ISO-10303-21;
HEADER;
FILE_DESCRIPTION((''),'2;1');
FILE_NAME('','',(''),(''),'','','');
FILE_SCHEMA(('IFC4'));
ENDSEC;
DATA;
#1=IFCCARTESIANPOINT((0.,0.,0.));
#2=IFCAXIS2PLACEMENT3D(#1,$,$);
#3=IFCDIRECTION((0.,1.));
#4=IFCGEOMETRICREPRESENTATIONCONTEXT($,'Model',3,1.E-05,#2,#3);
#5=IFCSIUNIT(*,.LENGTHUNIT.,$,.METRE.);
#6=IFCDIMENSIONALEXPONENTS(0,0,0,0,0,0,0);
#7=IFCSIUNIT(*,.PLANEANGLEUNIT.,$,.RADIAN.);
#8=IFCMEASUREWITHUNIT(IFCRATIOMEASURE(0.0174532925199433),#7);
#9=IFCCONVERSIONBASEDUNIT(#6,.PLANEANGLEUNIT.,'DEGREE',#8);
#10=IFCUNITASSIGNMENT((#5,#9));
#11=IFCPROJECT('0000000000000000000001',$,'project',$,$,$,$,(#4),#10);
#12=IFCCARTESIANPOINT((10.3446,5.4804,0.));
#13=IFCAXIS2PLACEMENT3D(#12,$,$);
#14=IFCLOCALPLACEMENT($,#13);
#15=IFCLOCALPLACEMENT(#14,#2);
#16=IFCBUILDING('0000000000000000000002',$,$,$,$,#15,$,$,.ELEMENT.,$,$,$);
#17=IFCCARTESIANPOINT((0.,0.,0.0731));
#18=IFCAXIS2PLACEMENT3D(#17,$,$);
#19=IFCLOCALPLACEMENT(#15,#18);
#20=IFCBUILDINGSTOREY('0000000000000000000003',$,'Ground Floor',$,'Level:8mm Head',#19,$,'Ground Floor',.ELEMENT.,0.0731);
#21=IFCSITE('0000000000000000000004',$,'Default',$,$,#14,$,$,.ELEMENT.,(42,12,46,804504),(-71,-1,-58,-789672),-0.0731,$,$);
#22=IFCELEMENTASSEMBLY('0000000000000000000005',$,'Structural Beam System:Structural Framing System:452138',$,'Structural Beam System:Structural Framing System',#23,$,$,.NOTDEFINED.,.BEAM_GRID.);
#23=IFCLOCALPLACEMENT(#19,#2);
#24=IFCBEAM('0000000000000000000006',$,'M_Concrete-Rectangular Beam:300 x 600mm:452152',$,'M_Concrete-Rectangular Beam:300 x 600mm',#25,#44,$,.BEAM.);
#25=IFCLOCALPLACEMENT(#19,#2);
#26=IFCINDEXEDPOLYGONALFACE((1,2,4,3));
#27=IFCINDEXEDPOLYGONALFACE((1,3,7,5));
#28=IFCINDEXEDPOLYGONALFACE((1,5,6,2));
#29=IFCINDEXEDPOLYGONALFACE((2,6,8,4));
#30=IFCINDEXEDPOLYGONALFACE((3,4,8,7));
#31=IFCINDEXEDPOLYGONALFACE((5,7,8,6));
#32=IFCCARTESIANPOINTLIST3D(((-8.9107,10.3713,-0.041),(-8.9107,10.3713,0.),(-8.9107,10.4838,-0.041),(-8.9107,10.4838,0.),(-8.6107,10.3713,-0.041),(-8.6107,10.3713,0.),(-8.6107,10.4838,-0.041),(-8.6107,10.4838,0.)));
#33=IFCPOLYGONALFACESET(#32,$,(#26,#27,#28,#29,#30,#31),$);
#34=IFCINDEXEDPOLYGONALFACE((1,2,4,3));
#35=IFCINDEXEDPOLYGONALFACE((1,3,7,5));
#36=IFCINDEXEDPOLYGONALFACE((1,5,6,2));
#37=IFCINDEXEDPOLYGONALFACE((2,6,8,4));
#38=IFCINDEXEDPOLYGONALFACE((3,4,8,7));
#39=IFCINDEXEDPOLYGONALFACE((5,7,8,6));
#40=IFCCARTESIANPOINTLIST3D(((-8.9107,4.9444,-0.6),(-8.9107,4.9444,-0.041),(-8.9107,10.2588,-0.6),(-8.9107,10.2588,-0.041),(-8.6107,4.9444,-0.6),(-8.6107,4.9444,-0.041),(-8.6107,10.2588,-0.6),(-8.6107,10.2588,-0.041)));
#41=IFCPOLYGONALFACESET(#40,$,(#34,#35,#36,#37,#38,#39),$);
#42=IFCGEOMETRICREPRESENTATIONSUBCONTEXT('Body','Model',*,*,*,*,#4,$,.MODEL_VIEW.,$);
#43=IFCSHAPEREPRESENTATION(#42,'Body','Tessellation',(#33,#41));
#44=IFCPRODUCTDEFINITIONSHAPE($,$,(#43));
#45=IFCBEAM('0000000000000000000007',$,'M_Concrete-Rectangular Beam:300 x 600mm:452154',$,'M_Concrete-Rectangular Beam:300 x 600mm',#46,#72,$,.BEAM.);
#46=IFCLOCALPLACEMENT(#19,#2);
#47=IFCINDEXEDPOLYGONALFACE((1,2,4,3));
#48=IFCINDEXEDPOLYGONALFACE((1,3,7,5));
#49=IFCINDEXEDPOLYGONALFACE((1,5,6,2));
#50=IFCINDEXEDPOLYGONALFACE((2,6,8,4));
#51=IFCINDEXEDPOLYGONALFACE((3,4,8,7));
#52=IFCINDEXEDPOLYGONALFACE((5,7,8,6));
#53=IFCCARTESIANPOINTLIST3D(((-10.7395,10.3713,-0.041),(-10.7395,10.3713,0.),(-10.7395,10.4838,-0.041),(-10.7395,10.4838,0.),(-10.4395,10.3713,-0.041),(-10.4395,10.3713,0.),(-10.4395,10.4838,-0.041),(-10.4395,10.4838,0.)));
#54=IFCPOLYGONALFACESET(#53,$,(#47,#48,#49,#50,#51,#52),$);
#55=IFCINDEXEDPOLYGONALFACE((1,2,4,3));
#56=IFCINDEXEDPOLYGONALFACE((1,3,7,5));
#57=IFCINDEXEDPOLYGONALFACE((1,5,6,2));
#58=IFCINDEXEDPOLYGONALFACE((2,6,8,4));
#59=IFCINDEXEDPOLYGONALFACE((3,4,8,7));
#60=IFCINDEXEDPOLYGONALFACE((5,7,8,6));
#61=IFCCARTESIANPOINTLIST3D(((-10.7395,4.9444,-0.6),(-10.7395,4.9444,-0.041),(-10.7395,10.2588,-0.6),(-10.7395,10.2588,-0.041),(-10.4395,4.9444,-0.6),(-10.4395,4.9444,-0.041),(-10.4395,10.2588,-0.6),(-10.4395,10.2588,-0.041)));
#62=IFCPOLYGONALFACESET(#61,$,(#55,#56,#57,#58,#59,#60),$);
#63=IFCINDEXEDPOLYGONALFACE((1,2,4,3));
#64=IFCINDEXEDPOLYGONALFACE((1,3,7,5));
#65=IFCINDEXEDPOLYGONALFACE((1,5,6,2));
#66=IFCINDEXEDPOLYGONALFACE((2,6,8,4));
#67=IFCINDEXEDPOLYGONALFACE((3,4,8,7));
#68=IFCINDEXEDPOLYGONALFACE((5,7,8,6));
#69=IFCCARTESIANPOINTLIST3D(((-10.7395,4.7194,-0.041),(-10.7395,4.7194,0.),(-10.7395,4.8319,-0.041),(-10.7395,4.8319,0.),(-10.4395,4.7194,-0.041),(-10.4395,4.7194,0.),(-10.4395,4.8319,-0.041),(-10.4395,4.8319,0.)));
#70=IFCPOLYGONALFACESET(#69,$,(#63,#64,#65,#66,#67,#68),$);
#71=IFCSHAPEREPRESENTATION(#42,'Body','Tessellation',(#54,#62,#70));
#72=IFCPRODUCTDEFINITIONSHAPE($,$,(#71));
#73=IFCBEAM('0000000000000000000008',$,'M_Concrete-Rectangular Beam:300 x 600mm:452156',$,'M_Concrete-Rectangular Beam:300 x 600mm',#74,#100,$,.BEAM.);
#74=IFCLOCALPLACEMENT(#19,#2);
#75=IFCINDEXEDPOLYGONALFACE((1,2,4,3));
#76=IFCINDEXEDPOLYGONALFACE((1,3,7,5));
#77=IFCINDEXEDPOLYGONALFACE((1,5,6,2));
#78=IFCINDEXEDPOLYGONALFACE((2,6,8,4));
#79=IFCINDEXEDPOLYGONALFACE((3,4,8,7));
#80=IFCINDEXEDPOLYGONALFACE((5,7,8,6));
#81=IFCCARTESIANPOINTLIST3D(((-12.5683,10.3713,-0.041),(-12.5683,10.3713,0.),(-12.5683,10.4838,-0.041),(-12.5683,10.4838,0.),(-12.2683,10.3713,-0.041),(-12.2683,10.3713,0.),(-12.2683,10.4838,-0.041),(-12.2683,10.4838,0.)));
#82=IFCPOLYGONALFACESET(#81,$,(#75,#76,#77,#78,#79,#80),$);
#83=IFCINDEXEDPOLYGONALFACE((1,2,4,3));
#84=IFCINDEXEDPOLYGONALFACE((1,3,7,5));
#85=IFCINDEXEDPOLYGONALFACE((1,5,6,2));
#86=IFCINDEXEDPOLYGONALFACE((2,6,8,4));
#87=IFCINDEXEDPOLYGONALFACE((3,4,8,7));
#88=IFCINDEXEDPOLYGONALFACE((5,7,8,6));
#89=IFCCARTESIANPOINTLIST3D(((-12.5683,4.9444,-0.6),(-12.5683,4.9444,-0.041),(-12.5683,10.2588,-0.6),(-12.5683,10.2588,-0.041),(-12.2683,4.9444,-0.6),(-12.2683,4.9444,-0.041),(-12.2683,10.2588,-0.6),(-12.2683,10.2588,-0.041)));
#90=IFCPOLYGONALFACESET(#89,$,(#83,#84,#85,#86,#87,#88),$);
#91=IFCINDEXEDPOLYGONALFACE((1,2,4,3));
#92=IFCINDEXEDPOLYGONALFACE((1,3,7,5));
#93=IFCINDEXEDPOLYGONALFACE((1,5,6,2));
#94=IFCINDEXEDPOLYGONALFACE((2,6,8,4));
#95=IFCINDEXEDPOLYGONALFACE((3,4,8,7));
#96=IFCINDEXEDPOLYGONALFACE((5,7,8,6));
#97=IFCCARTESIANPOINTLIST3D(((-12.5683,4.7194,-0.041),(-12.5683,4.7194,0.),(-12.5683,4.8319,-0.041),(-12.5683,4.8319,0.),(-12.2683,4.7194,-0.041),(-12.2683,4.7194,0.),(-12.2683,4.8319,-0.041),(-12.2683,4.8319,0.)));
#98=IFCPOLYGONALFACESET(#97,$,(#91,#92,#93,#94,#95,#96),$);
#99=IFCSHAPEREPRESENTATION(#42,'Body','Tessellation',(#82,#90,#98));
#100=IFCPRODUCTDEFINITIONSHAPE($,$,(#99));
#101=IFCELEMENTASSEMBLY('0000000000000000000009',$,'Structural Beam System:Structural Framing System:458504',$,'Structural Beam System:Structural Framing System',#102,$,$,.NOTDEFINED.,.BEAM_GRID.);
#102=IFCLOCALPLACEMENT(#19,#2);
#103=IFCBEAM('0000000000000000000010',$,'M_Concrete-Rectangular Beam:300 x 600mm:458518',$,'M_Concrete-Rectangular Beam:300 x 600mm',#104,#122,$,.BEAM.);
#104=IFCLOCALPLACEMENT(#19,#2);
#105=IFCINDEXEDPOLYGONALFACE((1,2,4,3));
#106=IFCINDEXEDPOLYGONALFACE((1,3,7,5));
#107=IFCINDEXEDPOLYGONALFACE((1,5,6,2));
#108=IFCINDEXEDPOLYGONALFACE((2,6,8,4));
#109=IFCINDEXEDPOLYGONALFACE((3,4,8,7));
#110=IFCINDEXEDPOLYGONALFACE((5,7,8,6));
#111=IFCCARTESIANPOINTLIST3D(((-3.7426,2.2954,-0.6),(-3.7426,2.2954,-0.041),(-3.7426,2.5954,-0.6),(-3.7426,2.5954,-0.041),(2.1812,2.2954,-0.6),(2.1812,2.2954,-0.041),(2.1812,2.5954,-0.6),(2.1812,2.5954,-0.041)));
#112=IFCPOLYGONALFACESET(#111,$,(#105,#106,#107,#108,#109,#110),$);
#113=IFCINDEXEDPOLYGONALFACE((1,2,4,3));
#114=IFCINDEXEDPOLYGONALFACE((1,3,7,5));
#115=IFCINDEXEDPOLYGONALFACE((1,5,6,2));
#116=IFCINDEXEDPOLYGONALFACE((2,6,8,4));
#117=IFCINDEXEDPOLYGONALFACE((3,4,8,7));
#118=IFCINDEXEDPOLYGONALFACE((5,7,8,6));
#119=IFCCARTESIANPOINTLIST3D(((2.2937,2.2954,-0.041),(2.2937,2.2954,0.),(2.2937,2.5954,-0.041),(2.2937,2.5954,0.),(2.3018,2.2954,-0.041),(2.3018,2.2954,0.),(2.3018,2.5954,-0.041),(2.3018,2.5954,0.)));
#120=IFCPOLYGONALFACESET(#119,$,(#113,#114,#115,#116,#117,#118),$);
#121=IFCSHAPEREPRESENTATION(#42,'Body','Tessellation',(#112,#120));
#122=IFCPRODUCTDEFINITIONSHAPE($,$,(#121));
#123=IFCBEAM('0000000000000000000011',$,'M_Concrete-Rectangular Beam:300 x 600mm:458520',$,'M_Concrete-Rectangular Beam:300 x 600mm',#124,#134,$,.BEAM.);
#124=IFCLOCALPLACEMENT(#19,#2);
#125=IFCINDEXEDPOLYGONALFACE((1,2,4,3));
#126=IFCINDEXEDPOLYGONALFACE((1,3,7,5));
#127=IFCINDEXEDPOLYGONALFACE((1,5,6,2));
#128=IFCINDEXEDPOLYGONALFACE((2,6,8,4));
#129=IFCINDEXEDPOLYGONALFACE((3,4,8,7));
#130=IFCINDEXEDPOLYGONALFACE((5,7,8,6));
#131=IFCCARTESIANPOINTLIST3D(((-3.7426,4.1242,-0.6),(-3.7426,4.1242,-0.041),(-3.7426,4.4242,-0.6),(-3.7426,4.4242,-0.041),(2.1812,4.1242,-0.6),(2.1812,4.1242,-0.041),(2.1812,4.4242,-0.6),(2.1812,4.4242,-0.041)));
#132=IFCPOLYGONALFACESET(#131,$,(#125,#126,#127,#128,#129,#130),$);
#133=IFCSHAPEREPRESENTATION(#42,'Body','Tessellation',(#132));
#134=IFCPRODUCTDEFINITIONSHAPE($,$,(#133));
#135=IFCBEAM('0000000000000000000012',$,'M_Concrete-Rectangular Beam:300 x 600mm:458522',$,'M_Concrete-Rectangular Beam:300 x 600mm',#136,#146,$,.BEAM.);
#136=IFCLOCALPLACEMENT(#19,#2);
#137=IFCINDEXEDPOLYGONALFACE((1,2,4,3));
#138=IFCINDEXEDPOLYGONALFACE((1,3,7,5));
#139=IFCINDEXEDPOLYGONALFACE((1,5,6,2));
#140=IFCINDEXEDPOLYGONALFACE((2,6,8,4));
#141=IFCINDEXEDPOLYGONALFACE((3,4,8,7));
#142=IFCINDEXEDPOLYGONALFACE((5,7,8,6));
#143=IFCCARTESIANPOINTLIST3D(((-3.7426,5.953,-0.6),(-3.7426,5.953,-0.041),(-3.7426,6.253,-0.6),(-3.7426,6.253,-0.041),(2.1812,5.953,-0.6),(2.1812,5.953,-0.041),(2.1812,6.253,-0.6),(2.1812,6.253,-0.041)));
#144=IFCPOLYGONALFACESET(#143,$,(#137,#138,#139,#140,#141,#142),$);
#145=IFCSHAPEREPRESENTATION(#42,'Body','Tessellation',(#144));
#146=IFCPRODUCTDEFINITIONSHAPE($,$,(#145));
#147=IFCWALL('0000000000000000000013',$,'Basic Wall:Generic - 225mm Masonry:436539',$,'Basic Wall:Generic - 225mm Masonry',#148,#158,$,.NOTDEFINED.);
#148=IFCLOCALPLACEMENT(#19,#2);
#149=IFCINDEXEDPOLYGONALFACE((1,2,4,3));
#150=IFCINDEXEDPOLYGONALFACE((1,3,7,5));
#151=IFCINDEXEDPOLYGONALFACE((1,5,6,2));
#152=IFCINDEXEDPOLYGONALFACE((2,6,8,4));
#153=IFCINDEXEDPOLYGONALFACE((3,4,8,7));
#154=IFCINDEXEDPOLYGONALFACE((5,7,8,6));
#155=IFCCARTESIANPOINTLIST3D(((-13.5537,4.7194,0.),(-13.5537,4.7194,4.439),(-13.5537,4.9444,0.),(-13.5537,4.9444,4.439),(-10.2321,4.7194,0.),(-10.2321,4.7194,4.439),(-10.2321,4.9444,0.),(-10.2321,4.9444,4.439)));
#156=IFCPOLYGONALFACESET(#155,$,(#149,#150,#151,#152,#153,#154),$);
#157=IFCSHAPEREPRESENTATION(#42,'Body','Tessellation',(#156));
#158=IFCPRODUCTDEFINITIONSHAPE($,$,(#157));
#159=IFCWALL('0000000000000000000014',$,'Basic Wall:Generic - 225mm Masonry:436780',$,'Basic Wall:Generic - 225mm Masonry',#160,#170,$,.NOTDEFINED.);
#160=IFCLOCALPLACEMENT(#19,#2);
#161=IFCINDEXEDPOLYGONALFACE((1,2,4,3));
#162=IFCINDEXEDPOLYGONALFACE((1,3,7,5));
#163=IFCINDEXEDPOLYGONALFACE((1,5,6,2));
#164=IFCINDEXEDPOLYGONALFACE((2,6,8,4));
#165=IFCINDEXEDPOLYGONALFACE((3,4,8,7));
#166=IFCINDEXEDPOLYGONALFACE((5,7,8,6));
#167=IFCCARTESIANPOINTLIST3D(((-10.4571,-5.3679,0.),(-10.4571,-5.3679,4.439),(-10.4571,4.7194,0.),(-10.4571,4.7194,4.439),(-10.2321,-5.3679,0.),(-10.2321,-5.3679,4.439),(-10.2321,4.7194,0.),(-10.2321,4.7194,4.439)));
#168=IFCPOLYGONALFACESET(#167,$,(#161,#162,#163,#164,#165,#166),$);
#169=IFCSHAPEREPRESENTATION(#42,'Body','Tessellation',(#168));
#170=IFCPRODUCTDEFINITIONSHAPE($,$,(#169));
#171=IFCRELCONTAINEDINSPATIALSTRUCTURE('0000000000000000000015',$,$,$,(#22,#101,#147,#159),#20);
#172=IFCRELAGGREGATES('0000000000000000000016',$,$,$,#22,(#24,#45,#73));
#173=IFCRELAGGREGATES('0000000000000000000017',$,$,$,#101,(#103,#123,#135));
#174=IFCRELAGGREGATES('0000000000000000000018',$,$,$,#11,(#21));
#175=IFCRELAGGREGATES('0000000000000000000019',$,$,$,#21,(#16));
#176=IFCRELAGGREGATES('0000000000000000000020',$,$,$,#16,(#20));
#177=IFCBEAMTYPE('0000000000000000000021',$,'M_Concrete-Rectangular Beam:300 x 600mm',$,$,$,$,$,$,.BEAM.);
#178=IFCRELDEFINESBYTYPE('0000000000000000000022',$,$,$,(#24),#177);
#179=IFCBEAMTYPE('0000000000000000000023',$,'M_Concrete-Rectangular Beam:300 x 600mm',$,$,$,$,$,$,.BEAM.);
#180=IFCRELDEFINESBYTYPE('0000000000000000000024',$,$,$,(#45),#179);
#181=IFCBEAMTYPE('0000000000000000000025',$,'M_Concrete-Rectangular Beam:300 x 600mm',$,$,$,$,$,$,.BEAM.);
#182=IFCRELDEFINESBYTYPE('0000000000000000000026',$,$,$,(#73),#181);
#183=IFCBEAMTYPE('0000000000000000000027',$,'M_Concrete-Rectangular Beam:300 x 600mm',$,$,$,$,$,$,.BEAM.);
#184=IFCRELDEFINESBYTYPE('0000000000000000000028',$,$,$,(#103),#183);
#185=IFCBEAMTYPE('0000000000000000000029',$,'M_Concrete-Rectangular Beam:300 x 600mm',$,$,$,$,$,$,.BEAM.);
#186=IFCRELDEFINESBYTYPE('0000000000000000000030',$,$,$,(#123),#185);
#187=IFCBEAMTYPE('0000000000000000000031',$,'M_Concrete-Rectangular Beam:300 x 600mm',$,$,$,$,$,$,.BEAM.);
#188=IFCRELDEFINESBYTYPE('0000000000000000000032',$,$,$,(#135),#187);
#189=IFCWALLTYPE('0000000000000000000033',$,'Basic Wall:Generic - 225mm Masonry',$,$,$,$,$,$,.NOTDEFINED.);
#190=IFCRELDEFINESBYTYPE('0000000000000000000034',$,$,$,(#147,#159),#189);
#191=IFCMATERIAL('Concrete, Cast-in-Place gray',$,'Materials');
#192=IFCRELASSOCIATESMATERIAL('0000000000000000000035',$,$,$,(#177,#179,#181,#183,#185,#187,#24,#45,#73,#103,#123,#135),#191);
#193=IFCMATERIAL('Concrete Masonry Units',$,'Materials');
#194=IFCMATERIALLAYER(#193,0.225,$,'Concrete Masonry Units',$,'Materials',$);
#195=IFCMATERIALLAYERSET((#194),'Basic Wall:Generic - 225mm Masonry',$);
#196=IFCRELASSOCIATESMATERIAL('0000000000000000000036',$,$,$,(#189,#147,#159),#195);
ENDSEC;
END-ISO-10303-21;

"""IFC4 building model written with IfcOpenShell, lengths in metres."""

from ifc_helpers import new_model, entity, si_unit, converted_unit, direction, frame, frame_2d, origin, place, context, subcontext, project, spatial, polyline, rectangle, extrude, clip, bounded_halfspace, source, transform, mapped, material, layer, layer_set, layer_usage, material_profile, profile_set, profile_usage, type_object, type_shapes, element, aggregate, save


model = new_model("IFC4")

# Units and contexts
model_context = context("Model", 3, precision=1e-05, world=origin(), true_north=direction((0.0, 1.0)))
body_context = subcontext(model_context, "Body", "Model", "MODEL_VIEW")
ifc_project = project(units=[si_unit("LENGTHUNIT", "METRE"), converted_unit("PLANEANGLEUNIT", "DEGREE", entity("IfcRatioMeasure", 0.0174532925199433), si_unit("PLANEANGLEUNIT", "RADIAN"), dimensions=[0, 0, 0, 0, 0, 0, 0])], contexts=[model_context])

# Site, building, storey
site_placement = place(None, frame((10.3446, 5.4804, 0.0)))
site = spatial("IfcSite", under=ifc_project, at=site_placement, Name="Default", CompositionType="ELEMENT", RefLatitude=(42, 12, 46, 804504), RefLongitude=(-71, -1, -58, -789672), RefElevation=-0.0731)
building_placement = place(site_placement, origin())
building = spatial("IfcBuilding", under=site, at=building_placement, CompositionType="ELEMENT")
storey_placement = place(building_placement, frame((0.0, 0.0, 0.0731)))
storey = spatial("IfcBuildingStorey", under=building, at=storey_placement, Name="Ground Floor", ObjectType="Level:8mm Head", LongName="Ground Floor", CompositionType="ELEMENT", Elevation=0.0731)

# Element assemblies, beams
ifc_material_1 = material(Name="Concrete, Cast-in-Place gray", Category="Materials")
ifc_material_profile = material_profile(ifc_material_1, rectangle(XDim=0.559, YDim=0.3, at=frame_2d((0.0, 0.0), x_axis=(1.0, 0.0))), Name="300 x 600mm")
ifc_profile_set = profile_set([ifc_material_profile], Name="300 x 600mm")
assembly_1_placement = place(storey_placement, origin())
assembly_1 = element("IfcElementAssembly", 1, at=assembly_1_placement, inside=storey, Name="Structural Beam System:Structural Framing System:452138", ObjectType="Structural Beam System:Structural Framing System", AssemblyPlace="NOTDEFINED", PredefinedType="BEAM_GRID")
ifc_profile_usage_1 = profile_usage(ifc_profile_set, cardinal=8)
beam_type_1 = type_object("IfcBeamType", Name="M_Concrete-Rectangular Beam:300 x 600mm", PredefinedType="BEAM", material=ifc_profile_set)
shared_shape_1 = source(origin(), body_context, "Body", "SweptSolid", [
    extrude(rectangle(XDim=0.041, YDim=0.3, at=frame_2d((0.0, 0.0), x_axis=(0.0, 1.0))), frame((-8.7607, 10.4838, 0.0526), z_axis=(0.0, -1.0, 0.0), x_axis=(-1.0, 0.0, 0.0)), (0.0, 0.0, 1.0), 0.1125),
    extrude(rectangle(XDim=0.559, YDim=0.3, at=frame_2d((0.0, 0.0), x_axis=(0.0, 1.0))), frame((-8.7607, 10.2588, -0.2474), z_axis=(0.0, -1.0, 0.0), x_axis=(-1.0, 0.0, 0.0)), (0.0, 0.0, 1.0), 5.3144),
])
type_shapes(beam_type_1, [shared_shape_1])
beam_1_placement = place(assembly_1_placement, frame((0.0, 0.0, -0.0731)))
beam_1 = element("IfcBeam", 2, at=beam_1_placement, type_object=beam_type_1, material=ifc_profile_usage_1, Name="M_Concrete-Rectangular Beam:300 x 600mm:452152", ObjectType="M_Concrete-Rectangular Beam:300 x 600mm", PredefinedType="BEAM", context=body_context, shape_type="MappedRepresentation", body=[
    mapped(shared_shape_1, transform((0.0, 0.0, 0.0), scale=1.0)),
])
ifc_profile_usage_2 = profile_usage(ifc_profile_set, cardinal=8)
beam_type_2 = type_object("IfcBeamType", Name="M_Concrete-Rectangular Beam:300 x 600mm", PredefinedType="BEAM", material=ifc_profile_set)
shared_shape_2 = source(origin(), body_context, "Body", "SweptSolid", [
    extrude(rectangle(XDim=0.041, YDim=0.3, at=frame_2d((0.0, 0.0), x_axis=(0.0, 1.0))), frame((-10.5895, 10.4838, 0.0526), z_axis=(0.0, -1.0, 0.0), x_axis=(-1.0, 0.0, 0.0)), (0.0, 0.0, 1.0), 0.1125),
    extrude(rectangle(XDim=0.559, YDim=0.3, at=frame_2d((0.0, 0.0), x_axis=(0.0, 1.0))), frame((-10.5895, 10.2588, -0.2474), z_axis=(0.0, -1.0, 0.0), x_axis=(-1.0, 0.0, 0.0)), (0.0, 0.0, 1.0), 5.3144),
    extrude(rectangle(XDim=0.041, YDim=0.3, at=frame_2d((0.0, 0.0), x_axis=(0.0, 1.0))), frame((-10.5895, 4.8319, 0.0526), z_axis=(0.0, -1.0, 0.0), x_axis=(-1.0, 0.0, 0.0)), (0.0, 0.0, 1.0), 0.1125),
])
type_shapes(beam_type_2, [shared_shape_2])
beam_2_placement = place(assembly_1_placement, frame((0.0, 0.0, -0.0731)))
beam_2 = element("IfcBeam", 3, at=beam_2_placement, type_object=beam_type_2, material=ifc_profile_usage_2, Name="M_Concrete-Rectangular Beam:300 x 600mm:452154", ObjectType="M_Concrete-Rectangular Beam:300 x 600mm", PredefinedType="BEAM", context=body_context, shape_type="MappedRepresentation", body=[
    mapped(shared_shape_2, transform((0.0, 0.0, 0.0), scale=1.0)),
])
ifc_profile_usage_3 = profile_usage(ifc_profile_set, cardinal=8)
beam_type_3 = type_object("IfcBeamType", Name="M_Concrete-Rectangular Beam:300 x 600mm", PredefinedType="BEAM", material=ifc_profile_set)
shared_shape_3 = source(origin(), body_context, "Body", "SweptSolid", [
    extrude(rectangle(XDim=0.041, YDim=0.3, at=frame_2d((0.0, 0.0), x_axis=(0.0, 1.0))), frame((-12.4183, 10.4838, 0.0526), z_axis=(0.0, -1.0, 0.0), x_axis=(-1.0, 0.0, 0.0)), (0.0, 0.0, 1.0), 0.1125),
    extrude(rectangle(XDim=0.559, YDim=0.3, at=frame_2d((0.0, 0.0), x_axis=(0.0, 1.0))), frame((-12.4183, 10.2588, -0.2474), z_axis=(0.0, -1.0, 0.0), x_axis=(-1.0, 0.0, 0.0)), (0.0, 0.0, 1.0), 5.3144),
    extrude(rectangle(XDim=0.041, YDim=0.3, at=frame_2d((0.0, 0.0), x_axis=(0.0, 1.0))), frame((-12.4183, 4.8319, 0.0526), z_axis=(0.0, -1.0, 0.0), x_axis=(-1.0, 0.0, 0.0)), (0.0, 0.0, 1.0), 0.1125),
])
type_shapes(beam_type_3, [shared_shape_3])
beam_3_placement = place(assembly_1_placement, frame((0.0, 0.0, -0.0731)))
beam_3 = element("IfcBeam", 4, at=beam_3_placement, type_object=beam_type_3, material=ifc_profile_usage_3, Name="M_Concrete-Rectangular Beam:300 x 600mm:452156", ObjectType="M_Concrete-Rectangular Beam:300 x 600mm", PredefinedType="BEAM", context=body_context, shape_type="MappedRepresentation", body=[
    mapped(shared_shape_3, transform((0.0, 0.0, 0.0), scale=1.0)),
])
aggregate(assembly_1, [beam_1, beam_2, beam_3])
assembly_2_placement = place(storey_placement, origin())
assembly_2 = element("IfcElementAssembly", 5, at=assembly_2_placement, inside=storey, Name="Structural Beam System:Structural Framing System:458504", ObjectType="Structural Beam System:Structural Framing System", AssemblyPlace="NOTDEFINED", PredefinedType="BEAM_GRID")
ifc_profile_usage_4 = profile_usage(ifc_profile_set, cardinal=8)
beam_type_4 = type_object("IfcBeamType", Name="M_Concrete-Rectangular Beam:300 x 600mm", PredefinedType="BEAM", material=ifc_profile_set)
shared_shape_4 = source(origin(), body_context, "Body", "SweptSolid", [
    extrude(rectangle(XDim=0.559, YDim=0.3, at=frame_2d((0.0, 0.0), x_axis=(1.0, 0.0))), frame((2.1812, 2.4454, -0.2474), z_axis=(-1.0, 0.0, 0.0), x_axis=(0.0, 0.0, -1.0)), (0.0, 0.0, 1.0), 5.9238),
    extrude(rectangle(XDim=0.041, YDim=0.3, at=frame_2d((0.0, 0.0), x_axis=(1.0, 0.0))), frame((2.3018, 2.4454, 0.0526), z_axis=(-1.0, 0.0, 0.0), x_axis=(0.0, 0.0, -1.0)), (0.0, 0.0, 1.0), 0.0082),
])
type_shapes(beam_type_4, [shared_shape_4])
beam_4_placement = place(assembly_2_placement, frame((0.0, 0.0, -0.0731)))
beam_4 = element("IfcBeam", 6, at=beam_4_placement, type_object=beam_type_4, material=ifc_profile_usage_4, Name="M_Concrete-Rectangular Beam:300 x 600mm:458518", ObjectType="M_Concrete-Rectangular Beam:300 x 600mm", PredefinedType="BEAM", context=body_context, shape_type="MappedRepresentation", body=[
    mapped(shared_shape_4, transform((0.0, 0.0, 0.0), scale=1.0)),
])
ifc_profile_usage_5 = profile_usage(ifc_profile_set, cardinal=8)
beam_type_5 = type_object("IfcBeamType", Name="M_Concrete-Rectangular Beam:300 x 600mm", PredefinedType="BEAM", material=ifc_profile_set)
shared_shape_5 = source(origin(), body_context, "Body", "SweptSolid", [
    extrude(rectangle(XDim=0.559, YDim=0.3, at=frame_2d((0.0, 0.0), x_axis=(1.0, 0.0))), frame((2.1812, 4.2742, -0.2474), z_axis=(-1.0, 0.0, 0.0), x_axis=(0.0, 0.0, -1.0)), (0.0, 0.0, 1.0), 5.9238),
])
type_shapes(beam_type_5, [shared_shape_5])
beam_5_placement = place(assembly_2_placement, frame((0.0, 0.0, -0.0731)))
beam_5 = element("IfcBeam", 7, at=beam_5_placement, type_object=beam_type_5, material=ifc_profile_usage_5, Name="M_Concrete-Rectangular Beam:300 x 600mm:458520", ObjectType="M_Concrete-Rectangular Beam:300 x 600mm", PredefinedType="BEAM", context=body_context, shape_type="MappedRepresentation", body=[
    mapped(shared_shape_5, transform((0.0, 0.0, 0.0), scale=1.0)),
])
ifc_profile_usage_6 = profile_usage(ifc_profile_set, cardinal=8)
beam_type_6 = type_object("IfcBeamType", Name="M_Concrete-Rectangular Beam:300 x 600mm", PredefinedType="BEAM", material=ifc_profile_set)
shared_shape_6 = source(origin(), body_context, "Body", "SweptSolid", [
    extrude(rectangle(XDim=0.559, YDim=0.3, at=frame_2d((0.0, 0.0), x_axis=(1.0, 0.0))), frame((2.1812, 6.103, -0.2474), z_axis=(-1.0, 0.0, 0.0), x_axis=(0.0, 0.0, -1.0)), (0.0, 0.0, 1.0), 5.9238),
])
type_shapes(beam_type_6, [shared_shape_6])
beam_6_placement = place(assembly_2_placement, frame((0.0, 0.0, -0.0731)))
beam_6 = element("IfcBeam", 8, at=beam_6_placement, type_object=beam_type_6, material=ifc_profile_usage_6, Name="M_Concrete-Rectangular Beam:300 x 600mm:458522", ObjectType="M_Concrete-Rectangular Beam:300 x 600mm", PredefinedType="BEAM", context=body_context, shape_type="MappedRepresentation", body=[
    mapped(shared_shape_6, transform((0.0, 0.0, 0.0), scale=1.0)),
])
aggregate(assembly_2, [beam_4, beam_5, beam_6])

# Walls
ifc_material_2 = material(Name="Concrete Masonry Units", Category="Materials")
ifc_layer = layer(ifc_material_2, 0.225, Name="Concrete Masonry Units", Category="Materials")
ifc_layer_set = layer_set([ifc_layer], Name="Basic Wall:Generic - 225mm Masonry")
wall_type = type_object("IfcWallType", Name="Basic Wall:Generic - 225mm Masonry", PredefinedType="NOTDEFINED", material=ifc_layer_set)
ifc_layer_usage_1 = layer_usage(ifc_layer_set, "AXIS2", "NEGATIVE", 0.1125)
wall_1_placement = place(storey_placement, frame((-13.5537, 4.8319, 0.0)))
element("IfcWall", 9, at=wall_1_placement, inside=storey, type_object=wall_type, material=ifc_layer_usage_1, Name="Basic Wall:Generic - 225mm Masonry:436539", ObjectType="Basic Wall:Generic - 225mm Masonry", PredefinedType="NOTDEFINED", context=body_context, shape_type="Clipping", body=[
    clip(extrude(rectangle(XDim=3.3216, YDim=0.225, at=frame_2d((1.6608, 0.0), x_axis=(-1.0, 0.0))), origin(), (0.0, 0.0, 1.0), 4.439), bounded_halfspace(frame((3.2091, -0.1125, 4.439), z_axis=(0.0, 0.0, -1.0), x_axis=(0.0, -1.0, 0.0)), True, frame((3.2091, -0.1125, 4.439)), polyline([(0.0, 0.0), (0.1125, 0.0), (0.1125, 0.1125), (0.0, 0.1125), (0.0, 0.0)]))),
])
ifc_layer_usage_2 = layer_usage(ifc_layer_set, "AXIS2", "NEGATIVE", 0.1125)
wall_2_placement = place(storey_placement, frame((-10.3446, 4.7194, 0.0), z_axis=(0.0, 0.0, 1.0), x_axis=(0.0, -1.0, 0.0)))
element("IfcWall", 10, at=wall_2_placement, inside=storey, type_object=wall_type, material=ifc_layer_usage_2, Name="Basic Wall:Generic - 225mm Masonry:436780", ObjectType="Basic Wall:Generic - 225mm Masonry", PredefinedType="NOTDEFINED", context=body_context, shape_type="Clipping", body=[
    clip(extrude(rectangle(XDim=10.0873, YDim=0.225, at=frame_2d((5.0437, 0.0), x_axis=(-1.0, 0.0))), origin(), (0.0, 0.0, 1.0), 4.439), bounded_halfspace(frame((10.0873, 0.0, 4.439), z_axis=(0.0, 0.0, -1.0), x_axis=(1.0, 0.0, 0.0)), True, frame((10.0873, 0.0, 4.439)), polyline([(0.0, 0.0), (0.0, 0.1125), (-10.0873, 0.1125), (-10.0873, 0.0), (0.0, 0.0)]))),
])

save(model, "model.ifc")
